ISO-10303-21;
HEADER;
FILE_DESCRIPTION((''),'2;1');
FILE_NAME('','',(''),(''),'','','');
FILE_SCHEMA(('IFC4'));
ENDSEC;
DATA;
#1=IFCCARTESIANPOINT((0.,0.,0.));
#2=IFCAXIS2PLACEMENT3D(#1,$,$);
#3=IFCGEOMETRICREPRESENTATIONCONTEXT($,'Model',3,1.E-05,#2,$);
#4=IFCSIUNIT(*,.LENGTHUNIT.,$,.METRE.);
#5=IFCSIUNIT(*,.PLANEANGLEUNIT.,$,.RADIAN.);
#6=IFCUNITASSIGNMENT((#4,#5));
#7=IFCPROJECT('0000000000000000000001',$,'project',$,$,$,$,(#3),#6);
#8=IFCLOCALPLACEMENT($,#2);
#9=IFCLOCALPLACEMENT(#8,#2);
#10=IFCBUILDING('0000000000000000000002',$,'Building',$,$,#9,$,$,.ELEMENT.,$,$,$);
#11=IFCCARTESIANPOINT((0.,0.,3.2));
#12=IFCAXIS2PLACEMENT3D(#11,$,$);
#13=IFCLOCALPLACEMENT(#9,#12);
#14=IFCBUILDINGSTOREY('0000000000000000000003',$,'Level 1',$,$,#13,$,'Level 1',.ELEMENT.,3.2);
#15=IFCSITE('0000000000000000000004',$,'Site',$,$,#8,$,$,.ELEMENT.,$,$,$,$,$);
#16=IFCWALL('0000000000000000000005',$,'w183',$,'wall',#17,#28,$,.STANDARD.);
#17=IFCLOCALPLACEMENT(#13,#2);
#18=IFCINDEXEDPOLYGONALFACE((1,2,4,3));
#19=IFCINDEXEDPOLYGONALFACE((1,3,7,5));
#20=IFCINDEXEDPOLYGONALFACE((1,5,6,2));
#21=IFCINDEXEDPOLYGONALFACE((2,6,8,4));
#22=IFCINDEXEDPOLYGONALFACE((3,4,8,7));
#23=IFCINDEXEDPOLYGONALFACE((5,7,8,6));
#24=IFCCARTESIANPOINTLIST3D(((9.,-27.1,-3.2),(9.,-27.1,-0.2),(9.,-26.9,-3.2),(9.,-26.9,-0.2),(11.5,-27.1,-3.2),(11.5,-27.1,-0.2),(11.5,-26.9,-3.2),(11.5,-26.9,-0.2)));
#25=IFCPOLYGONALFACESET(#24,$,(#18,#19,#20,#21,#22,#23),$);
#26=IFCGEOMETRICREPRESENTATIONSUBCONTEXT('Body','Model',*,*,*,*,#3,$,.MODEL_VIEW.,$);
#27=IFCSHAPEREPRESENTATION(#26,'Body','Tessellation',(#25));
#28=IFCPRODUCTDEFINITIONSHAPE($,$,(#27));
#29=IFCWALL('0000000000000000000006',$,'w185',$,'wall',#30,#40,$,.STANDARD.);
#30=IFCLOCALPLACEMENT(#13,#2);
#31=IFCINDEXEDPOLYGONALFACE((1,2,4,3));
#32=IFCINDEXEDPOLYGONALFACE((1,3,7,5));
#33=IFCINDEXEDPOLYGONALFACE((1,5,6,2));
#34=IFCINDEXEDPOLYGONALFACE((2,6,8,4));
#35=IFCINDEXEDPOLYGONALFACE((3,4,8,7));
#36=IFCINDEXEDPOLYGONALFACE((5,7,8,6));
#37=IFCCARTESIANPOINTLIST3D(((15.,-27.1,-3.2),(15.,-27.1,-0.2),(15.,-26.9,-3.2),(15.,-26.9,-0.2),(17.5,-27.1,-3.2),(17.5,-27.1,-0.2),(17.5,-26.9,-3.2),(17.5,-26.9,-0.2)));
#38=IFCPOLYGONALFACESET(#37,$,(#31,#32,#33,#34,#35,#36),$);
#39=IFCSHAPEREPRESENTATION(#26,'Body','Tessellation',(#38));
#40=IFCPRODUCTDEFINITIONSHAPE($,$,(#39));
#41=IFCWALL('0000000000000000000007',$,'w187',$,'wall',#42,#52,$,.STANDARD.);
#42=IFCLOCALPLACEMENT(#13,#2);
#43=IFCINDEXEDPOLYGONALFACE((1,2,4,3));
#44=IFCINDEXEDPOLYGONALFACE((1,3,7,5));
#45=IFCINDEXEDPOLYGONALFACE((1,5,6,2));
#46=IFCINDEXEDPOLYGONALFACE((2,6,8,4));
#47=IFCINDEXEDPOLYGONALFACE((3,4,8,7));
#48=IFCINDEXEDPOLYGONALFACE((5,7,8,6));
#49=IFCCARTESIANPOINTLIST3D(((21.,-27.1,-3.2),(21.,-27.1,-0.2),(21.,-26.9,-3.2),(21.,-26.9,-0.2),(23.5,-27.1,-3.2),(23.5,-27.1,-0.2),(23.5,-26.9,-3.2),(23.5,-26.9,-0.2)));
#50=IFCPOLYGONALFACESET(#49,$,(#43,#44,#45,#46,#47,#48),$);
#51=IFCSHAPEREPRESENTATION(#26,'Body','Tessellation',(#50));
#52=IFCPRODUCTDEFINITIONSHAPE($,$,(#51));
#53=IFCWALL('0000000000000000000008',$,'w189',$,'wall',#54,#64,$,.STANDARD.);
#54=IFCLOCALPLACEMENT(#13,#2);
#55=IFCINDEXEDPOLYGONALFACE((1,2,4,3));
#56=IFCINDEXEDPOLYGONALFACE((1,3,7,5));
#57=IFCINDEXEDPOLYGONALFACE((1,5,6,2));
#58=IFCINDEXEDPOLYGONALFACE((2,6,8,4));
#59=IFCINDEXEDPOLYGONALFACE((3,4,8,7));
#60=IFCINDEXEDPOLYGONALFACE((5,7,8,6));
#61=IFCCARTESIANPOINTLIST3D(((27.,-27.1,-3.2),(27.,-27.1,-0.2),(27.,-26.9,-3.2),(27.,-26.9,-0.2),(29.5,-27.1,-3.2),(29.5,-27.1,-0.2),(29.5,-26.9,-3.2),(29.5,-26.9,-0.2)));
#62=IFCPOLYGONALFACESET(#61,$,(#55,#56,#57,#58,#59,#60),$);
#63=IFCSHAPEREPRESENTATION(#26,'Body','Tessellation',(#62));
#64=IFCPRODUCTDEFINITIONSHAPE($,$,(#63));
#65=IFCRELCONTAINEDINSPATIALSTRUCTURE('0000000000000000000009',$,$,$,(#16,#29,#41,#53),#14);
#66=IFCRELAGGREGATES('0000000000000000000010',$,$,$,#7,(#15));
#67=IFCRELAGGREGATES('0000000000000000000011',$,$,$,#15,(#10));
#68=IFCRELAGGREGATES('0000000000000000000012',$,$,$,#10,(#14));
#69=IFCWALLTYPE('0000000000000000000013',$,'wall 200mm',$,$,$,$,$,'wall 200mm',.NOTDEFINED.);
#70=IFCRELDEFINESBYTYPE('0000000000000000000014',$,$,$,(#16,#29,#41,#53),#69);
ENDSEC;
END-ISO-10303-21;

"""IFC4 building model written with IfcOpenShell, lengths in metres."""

from ifc_helpers import new_model, si_unit, frame, frame_2d, origin, place, context, subcontext, project, spatial, rectangle, extrude, type_object, element, save


model = new_model("IFC4")

# Units and contexts
model_context = context("Model", 3, precision=1e-05, world=origin())
body_context = subcontext(model_context, "Body", "Model", "MODEL_VIEW")
ifc_project = project(units=[si_unit("LENGTHUNIT", "METRE"), si_unit("PLANEANGLEUNIT", "RADIAN")], contexts=[model_context])

# Site, building, storey
site_placement = place(None, origin())
site = spatial("IfcSite", under=ifc_project, at=site_placement, Name="Site", CompositionType="ELEMENT")
building_placement = place(site_placement, origin())
building = spatial("IfcBuilding", under=site, at=building_placement, Name="Building", CompositionType="ELEMENT")
storey_placement = place(building_placement, frame((0.0, 0.0, 3.2)))
storey = spatial("IfcBuildingStorey", under=building, at=storey_placement, Name="Level 1", LongName="Level 1", CompositionType="ELEMENT", Elevation=3.2)

# Walls
wall_type = type_object("IfcWallType", Name="wall 200mm", ElementType="wall 200mm", PredefinedType="NOTDEFINED")
for number, where, z_axis, x_axis, name in (
    (1, (9.0, -27.0, -3.2), (0.0, 0.0, 1.0), (1.0, 0.0, 0.0), "w183"),
    (2, (15.0, -27.0, -3.2), (0.0, 0.0, 1.0), (1.0, 0.0, 0.0), "w185"),
    (3, (21.0, -27.0, -3.2), (0.0, 0.0, 1.0), (1.0, 0.0, 0.0), "w187"),
    (4, (27.0, -27.0, -3.2), (0.0, 0.0, 1.0), (1.0, 0.0, 0.0), "w189"),
):
    element("IfcWall", number, at=place(storey_placement, frame(where, z_axis=z_axis, x_axis=x_axis)), inside=storey, type_object=wall_type, Name=name, ObjectType="wall", PredefinedType="STANDARD", context=body_context, shape_type="SweptSolid", body=[
        extrude(rectangle(XDim=2.5, YDim=0.2, at=frame_2d((1.25, 0.0))), origin(), (0.0, 0.0, 1.0), 3.0),
    ])

save(model, "model.ifc")
